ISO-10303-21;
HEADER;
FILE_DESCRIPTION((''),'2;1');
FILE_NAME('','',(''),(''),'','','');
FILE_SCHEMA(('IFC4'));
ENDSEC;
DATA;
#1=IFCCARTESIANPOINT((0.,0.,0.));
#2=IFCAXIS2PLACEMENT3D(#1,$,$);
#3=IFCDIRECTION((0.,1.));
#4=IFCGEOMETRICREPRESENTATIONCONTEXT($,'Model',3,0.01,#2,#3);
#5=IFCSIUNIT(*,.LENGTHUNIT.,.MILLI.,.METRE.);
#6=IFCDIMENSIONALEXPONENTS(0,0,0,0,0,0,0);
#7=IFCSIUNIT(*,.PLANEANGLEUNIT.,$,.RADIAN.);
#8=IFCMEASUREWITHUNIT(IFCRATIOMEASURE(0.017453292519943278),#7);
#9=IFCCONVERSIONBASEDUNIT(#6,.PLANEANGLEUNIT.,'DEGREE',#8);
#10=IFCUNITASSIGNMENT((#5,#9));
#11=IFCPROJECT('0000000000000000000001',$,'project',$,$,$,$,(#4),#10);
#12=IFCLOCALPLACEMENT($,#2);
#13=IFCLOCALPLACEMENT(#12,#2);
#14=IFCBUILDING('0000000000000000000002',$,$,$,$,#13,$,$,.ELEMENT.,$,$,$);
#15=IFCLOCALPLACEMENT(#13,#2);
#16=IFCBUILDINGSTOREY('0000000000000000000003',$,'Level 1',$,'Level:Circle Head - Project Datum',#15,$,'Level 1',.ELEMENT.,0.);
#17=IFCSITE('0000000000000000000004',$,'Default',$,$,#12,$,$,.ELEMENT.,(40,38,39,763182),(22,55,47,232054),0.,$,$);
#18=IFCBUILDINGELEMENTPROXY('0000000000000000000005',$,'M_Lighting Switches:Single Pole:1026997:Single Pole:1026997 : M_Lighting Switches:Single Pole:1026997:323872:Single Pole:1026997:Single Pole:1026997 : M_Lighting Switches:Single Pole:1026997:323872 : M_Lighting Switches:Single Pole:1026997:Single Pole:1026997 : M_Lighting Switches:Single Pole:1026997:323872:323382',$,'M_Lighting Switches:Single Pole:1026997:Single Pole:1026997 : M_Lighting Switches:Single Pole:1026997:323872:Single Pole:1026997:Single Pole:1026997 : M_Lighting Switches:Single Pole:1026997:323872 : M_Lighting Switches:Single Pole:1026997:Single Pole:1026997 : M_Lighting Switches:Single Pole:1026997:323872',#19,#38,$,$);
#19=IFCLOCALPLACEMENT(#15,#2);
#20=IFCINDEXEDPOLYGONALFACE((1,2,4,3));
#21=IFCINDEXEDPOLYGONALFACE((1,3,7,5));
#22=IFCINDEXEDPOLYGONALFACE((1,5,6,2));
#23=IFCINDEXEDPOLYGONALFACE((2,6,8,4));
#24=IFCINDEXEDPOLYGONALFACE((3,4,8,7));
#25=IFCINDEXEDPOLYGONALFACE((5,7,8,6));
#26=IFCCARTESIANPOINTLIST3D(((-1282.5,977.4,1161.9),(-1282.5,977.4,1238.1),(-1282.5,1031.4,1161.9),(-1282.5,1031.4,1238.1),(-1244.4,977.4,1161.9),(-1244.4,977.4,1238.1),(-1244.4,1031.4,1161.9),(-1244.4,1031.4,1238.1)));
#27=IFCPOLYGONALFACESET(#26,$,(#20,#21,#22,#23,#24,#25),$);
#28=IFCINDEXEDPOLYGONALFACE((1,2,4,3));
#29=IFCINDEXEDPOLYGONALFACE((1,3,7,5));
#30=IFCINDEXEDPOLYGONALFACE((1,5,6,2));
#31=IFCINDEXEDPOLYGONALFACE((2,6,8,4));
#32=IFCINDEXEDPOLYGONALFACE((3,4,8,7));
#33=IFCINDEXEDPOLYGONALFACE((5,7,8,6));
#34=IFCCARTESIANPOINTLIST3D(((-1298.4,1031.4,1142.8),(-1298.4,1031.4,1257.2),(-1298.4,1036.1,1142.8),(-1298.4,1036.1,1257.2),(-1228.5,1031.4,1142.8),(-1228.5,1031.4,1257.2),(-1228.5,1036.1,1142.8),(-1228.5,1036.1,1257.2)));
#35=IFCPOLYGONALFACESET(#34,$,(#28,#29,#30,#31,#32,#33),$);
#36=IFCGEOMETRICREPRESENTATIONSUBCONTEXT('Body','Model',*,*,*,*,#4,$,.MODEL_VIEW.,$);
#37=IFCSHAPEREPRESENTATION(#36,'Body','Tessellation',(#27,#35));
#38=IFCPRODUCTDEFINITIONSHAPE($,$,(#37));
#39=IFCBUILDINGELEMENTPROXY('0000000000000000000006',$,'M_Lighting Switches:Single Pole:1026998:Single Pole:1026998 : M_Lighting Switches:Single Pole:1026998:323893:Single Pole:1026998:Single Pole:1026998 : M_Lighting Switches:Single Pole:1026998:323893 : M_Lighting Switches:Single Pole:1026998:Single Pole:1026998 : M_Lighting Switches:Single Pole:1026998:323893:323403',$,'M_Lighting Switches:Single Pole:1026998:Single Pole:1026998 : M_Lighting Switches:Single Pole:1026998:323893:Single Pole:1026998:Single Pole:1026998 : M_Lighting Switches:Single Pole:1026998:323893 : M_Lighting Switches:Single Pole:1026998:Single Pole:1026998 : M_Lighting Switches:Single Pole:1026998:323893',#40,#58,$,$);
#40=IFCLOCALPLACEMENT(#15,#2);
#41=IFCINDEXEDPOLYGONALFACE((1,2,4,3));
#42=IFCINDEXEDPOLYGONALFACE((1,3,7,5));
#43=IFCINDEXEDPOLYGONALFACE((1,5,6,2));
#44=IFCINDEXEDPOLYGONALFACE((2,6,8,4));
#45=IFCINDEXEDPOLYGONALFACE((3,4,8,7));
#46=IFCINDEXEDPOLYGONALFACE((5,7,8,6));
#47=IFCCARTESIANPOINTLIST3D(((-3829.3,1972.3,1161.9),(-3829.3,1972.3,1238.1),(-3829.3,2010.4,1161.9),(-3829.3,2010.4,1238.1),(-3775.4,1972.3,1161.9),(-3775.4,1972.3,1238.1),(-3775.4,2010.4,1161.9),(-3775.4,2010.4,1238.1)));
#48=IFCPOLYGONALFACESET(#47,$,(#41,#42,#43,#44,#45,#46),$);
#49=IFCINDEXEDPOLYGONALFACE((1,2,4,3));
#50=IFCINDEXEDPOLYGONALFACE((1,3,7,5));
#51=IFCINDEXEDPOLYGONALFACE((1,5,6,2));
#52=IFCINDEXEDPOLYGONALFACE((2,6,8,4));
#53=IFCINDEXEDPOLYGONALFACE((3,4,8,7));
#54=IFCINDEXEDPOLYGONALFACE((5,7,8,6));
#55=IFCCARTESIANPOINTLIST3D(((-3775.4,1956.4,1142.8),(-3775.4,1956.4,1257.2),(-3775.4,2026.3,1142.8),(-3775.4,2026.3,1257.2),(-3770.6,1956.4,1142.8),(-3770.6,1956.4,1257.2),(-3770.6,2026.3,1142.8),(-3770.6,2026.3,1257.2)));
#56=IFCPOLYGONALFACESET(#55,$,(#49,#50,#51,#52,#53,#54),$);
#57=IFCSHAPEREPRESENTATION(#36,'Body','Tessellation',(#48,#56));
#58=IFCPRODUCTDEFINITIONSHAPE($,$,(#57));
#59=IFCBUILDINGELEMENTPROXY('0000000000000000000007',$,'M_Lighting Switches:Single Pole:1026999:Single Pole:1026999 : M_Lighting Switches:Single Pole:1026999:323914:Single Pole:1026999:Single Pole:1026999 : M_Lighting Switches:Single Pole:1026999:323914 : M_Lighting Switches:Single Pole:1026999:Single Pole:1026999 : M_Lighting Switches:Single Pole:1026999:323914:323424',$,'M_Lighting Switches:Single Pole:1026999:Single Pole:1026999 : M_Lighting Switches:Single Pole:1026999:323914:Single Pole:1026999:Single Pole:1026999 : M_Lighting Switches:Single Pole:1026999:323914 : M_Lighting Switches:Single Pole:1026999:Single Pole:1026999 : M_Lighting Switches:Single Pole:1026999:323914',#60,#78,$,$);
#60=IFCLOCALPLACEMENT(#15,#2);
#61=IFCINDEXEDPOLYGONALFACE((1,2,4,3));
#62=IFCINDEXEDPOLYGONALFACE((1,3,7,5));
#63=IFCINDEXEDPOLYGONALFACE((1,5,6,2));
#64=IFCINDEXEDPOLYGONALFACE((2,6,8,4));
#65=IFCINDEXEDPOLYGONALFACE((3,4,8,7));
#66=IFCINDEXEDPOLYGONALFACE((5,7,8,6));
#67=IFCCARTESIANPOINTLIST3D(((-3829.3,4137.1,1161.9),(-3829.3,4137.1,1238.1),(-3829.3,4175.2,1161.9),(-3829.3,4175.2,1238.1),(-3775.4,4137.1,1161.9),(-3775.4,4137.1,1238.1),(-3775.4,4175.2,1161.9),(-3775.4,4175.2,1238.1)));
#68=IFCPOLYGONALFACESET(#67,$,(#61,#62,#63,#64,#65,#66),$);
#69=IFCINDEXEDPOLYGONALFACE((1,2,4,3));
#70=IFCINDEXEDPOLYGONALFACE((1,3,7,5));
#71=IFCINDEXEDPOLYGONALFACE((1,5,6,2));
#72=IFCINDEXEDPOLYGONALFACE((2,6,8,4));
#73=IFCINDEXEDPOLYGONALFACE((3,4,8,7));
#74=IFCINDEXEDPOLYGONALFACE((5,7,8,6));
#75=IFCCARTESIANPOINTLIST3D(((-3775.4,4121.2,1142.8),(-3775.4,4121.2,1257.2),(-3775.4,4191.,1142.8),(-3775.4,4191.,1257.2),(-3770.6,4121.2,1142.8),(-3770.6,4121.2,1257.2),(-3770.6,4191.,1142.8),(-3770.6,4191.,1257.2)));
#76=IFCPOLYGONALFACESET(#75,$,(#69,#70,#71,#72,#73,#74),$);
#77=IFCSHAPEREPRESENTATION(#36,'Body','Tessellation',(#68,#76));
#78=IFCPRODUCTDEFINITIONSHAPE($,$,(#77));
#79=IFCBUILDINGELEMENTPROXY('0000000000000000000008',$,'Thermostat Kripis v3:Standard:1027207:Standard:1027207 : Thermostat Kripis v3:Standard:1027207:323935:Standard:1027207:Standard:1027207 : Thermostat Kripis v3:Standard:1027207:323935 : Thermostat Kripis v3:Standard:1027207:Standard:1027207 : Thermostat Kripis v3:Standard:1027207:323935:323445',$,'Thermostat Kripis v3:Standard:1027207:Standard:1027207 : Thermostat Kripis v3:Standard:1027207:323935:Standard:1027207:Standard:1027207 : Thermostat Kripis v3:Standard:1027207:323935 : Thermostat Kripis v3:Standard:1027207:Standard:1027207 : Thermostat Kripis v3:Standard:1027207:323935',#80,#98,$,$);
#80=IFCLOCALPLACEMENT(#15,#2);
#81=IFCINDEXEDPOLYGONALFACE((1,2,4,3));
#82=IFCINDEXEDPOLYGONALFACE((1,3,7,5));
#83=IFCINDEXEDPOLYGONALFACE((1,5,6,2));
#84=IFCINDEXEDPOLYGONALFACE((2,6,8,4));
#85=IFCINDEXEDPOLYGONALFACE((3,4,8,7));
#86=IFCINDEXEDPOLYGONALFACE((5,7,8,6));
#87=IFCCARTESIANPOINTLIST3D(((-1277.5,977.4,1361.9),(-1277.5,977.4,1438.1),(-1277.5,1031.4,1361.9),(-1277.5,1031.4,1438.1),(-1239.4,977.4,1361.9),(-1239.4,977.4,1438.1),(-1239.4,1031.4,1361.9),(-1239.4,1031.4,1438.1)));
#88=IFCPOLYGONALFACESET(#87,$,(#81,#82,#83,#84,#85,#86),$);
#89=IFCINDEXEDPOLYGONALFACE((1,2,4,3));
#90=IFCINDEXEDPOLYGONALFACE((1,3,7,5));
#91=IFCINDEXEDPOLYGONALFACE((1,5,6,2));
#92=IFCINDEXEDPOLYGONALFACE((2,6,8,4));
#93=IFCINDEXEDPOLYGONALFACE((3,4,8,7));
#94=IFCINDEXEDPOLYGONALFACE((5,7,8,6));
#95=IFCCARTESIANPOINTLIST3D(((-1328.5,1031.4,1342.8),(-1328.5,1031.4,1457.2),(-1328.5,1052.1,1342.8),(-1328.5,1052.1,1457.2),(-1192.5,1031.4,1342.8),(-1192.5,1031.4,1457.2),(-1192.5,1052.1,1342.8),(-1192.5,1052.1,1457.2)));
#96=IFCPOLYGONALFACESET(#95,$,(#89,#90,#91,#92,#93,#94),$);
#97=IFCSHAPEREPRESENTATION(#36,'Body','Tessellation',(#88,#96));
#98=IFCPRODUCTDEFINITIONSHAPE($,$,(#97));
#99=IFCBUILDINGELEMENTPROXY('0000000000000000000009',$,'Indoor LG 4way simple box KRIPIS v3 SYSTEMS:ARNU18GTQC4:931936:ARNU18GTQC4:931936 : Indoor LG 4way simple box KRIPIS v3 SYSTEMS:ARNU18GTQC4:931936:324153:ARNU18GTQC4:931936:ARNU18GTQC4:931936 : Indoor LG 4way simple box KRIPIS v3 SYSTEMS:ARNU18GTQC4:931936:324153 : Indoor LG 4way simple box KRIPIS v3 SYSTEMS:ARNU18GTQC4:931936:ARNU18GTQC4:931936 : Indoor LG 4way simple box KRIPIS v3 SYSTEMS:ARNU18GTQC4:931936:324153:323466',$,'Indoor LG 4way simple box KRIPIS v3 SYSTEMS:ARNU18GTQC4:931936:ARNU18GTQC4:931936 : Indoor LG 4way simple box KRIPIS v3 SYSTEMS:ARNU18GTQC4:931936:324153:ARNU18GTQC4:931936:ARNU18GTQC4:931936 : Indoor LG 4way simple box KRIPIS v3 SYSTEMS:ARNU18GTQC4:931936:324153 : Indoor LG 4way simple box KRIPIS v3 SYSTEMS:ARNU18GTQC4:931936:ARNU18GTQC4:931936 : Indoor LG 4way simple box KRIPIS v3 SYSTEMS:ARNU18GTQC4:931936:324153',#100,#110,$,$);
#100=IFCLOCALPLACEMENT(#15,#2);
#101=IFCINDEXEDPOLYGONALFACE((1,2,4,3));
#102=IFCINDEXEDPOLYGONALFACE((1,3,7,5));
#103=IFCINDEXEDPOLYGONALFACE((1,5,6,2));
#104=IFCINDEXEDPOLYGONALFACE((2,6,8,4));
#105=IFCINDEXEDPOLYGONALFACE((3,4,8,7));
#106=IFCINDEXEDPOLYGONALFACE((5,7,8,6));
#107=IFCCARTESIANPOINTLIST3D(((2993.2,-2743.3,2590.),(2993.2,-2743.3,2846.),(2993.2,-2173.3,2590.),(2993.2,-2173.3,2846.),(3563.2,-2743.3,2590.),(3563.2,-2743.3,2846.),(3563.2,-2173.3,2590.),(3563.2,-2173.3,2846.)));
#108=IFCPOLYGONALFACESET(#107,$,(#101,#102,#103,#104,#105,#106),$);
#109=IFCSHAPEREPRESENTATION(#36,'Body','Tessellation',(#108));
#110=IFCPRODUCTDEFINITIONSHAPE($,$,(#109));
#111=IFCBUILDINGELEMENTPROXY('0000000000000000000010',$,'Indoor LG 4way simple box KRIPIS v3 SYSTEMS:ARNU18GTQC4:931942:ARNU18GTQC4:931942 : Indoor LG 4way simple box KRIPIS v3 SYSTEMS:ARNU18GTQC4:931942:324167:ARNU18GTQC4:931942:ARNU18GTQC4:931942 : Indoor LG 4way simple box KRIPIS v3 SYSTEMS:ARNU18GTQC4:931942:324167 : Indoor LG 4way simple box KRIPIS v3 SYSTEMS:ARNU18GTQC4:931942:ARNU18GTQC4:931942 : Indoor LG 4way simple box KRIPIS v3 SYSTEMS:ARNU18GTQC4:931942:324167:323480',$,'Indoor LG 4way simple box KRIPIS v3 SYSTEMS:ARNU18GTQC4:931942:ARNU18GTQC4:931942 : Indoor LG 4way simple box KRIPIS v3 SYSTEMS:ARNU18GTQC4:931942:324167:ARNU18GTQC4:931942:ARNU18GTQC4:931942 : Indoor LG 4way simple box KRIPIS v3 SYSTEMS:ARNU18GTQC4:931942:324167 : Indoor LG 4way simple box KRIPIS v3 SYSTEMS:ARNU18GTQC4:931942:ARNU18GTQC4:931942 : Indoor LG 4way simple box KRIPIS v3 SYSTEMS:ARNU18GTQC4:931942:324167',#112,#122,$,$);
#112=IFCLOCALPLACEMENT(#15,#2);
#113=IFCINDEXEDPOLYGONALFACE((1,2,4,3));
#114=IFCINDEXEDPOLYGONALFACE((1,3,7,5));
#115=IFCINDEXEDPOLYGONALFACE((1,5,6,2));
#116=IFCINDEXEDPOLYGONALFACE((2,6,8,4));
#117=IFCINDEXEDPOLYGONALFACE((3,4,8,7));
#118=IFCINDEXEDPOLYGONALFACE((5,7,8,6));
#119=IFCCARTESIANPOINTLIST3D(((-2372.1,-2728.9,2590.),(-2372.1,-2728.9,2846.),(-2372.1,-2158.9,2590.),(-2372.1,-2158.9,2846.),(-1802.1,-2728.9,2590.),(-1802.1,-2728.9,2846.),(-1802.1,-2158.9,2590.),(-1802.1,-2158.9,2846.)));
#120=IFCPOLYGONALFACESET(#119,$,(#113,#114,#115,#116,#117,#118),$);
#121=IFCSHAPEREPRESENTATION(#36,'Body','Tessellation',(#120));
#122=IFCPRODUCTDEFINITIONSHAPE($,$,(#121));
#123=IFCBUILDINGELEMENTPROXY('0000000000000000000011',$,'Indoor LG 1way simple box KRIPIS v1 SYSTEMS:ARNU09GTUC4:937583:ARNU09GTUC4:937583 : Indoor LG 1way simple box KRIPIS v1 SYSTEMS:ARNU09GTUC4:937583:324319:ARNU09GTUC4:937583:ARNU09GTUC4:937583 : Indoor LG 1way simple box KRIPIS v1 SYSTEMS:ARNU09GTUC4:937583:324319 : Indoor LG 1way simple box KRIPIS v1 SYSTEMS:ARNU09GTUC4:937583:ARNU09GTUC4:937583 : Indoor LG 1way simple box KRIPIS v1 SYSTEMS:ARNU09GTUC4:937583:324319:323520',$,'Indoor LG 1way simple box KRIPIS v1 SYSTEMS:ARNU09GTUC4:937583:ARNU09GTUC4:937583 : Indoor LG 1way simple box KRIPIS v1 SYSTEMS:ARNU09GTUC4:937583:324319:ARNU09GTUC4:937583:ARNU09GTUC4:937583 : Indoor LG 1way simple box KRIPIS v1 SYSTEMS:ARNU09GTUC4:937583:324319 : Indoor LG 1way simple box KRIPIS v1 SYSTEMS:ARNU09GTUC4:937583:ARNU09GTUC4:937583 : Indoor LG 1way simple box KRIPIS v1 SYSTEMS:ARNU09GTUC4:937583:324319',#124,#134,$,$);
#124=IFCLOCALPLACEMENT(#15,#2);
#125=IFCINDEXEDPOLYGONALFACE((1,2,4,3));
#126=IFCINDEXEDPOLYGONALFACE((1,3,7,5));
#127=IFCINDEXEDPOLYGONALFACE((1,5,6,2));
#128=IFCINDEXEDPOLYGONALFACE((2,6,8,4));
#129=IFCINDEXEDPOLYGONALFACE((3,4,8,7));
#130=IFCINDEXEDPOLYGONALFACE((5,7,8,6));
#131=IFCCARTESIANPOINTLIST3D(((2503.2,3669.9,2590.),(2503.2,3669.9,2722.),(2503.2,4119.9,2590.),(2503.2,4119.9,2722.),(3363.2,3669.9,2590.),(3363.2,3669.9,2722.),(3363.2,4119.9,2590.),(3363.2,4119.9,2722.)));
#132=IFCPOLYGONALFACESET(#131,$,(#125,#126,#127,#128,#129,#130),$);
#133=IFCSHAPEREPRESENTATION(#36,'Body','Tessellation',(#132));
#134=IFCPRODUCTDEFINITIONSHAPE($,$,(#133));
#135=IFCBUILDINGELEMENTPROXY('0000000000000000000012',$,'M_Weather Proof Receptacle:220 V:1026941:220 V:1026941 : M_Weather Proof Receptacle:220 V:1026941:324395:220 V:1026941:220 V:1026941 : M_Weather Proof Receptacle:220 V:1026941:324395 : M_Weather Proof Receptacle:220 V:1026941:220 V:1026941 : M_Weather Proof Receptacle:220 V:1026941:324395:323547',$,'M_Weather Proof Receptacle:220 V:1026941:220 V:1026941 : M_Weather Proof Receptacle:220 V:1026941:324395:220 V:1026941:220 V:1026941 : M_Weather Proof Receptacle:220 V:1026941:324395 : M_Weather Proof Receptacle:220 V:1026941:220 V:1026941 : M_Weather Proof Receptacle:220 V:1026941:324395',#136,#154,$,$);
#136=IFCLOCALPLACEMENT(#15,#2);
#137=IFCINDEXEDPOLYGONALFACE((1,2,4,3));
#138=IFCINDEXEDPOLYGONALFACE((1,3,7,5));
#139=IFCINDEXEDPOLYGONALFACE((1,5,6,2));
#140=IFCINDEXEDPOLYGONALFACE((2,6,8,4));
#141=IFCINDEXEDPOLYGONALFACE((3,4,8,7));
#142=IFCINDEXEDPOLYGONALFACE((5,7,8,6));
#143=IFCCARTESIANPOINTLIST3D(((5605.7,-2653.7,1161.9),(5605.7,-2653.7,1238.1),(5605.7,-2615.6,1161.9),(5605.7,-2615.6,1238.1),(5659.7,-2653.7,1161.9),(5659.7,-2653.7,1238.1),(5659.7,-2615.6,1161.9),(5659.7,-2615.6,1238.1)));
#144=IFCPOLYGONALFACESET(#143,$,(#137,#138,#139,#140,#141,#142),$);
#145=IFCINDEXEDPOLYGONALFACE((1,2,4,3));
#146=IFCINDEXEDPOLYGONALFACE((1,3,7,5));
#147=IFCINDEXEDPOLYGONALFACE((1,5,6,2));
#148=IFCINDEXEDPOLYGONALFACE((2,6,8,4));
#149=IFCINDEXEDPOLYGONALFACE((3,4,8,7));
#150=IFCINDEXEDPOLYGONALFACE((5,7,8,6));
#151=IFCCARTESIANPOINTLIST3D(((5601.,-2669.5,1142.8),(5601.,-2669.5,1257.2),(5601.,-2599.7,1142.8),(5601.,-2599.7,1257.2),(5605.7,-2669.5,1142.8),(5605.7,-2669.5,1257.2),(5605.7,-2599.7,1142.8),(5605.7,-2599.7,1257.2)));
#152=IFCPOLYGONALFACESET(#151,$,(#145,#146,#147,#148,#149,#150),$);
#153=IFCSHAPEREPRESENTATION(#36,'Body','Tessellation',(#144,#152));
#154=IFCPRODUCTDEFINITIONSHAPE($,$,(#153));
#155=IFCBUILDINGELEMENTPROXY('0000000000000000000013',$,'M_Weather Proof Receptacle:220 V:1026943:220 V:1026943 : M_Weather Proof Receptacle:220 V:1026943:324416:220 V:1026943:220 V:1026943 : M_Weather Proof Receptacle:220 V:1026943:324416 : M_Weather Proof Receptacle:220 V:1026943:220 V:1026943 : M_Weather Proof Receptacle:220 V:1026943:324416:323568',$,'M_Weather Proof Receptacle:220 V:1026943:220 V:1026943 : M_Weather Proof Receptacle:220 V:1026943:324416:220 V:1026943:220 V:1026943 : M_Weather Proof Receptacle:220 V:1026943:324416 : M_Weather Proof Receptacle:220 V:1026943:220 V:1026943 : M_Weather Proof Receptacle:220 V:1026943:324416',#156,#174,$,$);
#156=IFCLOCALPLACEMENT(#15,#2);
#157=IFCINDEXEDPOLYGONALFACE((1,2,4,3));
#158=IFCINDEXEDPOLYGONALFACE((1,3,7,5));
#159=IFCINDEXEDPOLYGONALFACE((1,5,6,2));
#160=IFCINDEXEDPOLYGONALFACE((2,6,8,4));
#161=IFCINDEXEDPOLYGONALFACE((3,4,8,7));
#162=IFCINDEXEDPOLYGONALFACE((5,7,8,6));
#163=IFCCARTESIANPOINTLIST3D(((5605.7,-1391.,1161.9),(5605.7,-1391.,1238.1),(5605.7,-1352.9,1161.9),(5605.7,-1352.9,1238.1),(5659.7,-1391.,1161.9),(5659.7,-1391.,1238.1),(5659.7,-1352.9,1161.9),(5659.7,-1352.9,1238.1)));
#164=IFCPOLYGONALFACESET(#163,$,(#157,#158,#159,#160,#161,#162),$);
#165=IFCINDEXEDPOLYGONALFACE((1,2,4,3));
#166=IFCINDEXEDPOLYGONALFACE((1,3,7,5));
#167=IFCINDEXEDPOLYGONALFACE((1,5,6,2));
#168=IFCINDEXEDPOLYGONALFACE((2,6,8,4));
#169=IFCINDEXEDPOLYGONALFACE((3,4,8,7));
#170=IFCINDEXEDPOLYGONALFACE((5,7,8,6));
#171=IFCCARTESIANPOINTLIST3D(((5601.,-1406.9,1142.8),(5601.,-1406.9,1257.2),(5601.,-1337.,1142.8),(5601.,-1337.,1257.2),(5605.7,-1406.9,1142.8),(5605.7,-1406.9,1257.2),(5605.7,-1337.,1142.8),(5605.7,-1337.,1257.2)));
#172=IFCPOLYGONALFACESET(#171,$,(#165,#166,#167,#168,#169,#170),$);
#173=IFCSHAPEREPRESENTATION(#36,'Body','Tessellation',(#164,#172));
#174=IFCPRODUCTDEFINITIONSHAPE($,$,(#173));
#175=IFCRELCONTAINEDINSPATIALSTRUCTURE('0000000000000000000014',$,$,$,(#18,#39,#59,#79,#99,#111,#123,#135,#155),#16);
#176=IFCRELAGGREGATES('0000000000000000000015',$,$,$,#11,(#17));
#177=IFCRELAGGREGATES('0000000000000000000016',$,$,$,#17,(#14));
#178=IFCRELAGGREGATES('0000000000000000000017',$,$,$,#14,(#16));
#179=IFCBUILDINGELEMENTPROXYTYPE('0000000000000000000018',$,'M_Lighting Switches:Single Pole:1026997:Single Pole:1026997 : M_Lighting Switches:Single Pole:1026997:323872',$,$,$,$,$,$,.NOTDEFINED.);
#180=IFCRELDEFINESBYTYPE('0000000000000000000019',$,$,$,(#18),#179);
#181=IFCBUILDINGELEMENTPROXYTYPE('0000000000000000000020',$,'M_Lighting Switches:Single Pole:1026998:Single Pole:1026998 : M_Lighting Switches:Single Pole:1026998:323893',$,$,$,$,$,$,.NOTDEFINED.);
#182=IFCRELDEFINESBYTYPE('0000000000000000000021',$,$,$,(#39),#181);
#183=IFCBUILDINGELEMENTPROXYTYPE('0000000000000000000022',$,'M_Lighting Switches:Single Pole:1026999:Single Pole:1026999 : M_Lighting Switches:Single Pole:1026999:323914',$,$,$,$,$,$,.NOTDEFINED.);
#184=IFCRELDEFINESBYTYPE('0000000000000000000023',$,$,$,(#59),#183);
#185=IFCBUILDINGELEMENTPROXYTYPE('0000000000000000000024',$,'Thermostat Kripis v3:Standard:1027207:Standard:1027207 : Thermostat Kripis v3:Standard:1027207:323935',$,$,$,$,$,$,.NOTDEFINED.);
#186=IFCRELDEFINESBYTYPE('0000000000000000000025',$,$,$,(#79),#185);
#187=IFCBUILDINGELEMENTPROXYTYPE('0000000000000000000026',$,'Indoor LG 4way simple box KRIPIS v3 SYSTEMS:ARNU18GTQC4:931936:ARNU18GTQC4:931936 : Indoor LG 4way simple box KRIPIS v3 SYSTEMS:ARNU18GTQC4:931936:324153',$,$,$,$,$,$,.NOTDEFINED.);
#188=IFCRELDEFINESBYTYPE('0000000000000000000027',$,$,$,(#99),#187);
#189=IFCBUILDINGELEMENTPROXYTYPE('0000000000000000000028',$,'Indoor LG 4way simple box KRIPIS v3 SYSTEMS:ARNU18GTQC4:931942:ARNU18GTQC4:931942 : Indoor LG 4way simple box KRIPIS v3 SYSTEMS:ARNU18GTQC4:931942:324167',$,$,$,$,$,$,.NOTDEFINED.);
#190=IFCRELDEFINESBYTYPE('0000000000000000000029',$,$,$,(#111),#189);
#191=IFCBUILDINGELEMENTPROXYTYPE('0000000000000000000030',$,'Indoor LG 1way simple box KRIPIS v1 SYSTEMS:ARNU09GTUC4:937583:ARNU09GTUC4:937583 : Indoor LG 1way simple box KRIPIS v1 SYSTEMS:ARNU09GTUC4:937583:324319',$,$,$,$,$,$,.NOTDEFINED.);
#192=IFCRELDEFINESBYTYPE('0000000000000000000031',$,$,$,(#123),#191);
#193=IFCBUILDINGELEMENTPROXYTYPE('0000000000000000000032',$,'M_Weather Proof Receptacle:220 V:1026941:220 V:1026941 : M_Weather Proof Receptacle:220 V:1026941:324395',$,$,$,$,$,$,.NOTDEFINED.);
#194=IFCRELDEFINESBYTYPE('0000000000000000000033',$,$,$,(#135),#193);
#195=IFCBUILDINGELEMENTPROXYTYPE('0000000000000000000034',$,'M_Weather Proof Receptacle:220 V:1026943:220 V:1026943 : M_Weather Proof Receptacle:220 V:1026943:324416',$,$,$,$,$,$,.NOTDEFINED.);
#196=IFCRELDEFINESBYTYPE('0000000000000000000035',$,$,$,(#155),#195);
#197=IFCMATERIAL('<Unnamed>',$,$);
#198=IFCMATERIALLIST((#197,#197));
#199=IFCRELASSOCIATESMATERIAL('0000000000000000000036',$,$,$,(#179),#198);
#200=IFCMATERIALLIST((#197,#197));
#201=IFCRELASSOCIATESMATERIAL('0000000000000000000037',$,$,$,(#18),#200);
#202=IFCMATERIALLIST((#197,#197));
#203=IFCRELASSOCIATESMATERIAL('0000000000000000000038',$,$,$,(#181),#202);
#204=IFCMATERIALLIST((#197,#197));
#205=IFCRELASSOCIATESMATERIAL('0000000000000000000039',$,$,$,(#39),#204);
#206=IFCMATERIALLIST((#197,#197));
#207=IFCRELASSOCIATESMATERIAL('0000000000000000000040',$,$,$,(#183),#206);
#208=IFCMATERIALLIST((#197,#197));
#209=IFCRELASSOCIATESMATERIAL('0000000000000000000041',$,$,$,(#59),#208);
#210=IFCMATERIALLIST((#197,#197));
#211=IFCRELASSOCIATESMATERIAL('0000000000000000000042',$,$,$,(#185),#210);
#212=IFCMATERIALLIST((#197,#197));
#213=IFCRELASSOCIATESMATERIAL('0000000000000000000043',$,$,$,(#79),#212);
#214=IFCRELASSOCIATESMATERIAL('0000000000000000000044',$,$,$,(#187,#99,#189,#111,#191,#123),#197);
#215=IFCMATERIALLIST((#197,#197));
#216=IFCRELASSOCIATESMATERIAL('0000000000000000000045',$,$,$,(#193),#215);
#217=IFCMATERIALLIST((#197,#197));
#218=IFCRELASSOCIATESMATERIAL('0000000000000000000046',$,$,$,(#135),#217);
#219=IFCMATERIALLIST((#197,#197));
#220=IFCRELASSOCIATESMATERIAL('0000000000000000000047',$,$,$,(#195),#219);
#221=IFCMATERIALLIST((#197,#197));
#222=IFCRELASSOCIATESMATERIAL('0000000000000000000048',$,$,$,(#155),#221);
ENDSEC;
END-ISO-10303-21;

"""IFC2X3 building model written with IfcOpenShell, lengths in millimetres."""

from ifc_helpers import new_model, entity, si_unit, converted_unit, direction, frame, frame_2d, origin, origin_2d_with_axis, place, context, subcontext, project, spatial, rectangle, extrude, source, transform, mapped, material, material_list, type_object, type_shapes, element, save


model = new_model("IFC2X3")

# Units and contexts
model_context = context("Model", 3, precision=0.01, world=origin(), true_north=direction((0.0, 1.0)))
body_context = subcontext(model_context, "Body", "Model", "MODEL_VIEW")
ifc_project = project(units=[si_unit("LENGTHUNIT", "METRE", prefix="MILLI"), converted_unit("PLANEANGLEUNIT", "DEGREE", entity("IfcRatioMeasure", 0.017453292519943278), si_unit("PLANEANGLEUNIT", "RADIAN"), dimensions=[0, 0, 0, 0, 0, 0, 0])], contexts=[model_context])

# Site, building, storey
site_placement = place(None, origin())
site = spatial("IfcSite", under=ifc_project, at=site_placement, Name="Default", CompositionType="ELEMENT", RefLatitude=(40, 38, 39, 763182), RefLongitude=(22, 55, 47, 232054), RefElevation=0.0)
building_placement = place(site_placement, origin())
building = spatial("IfcBuilding", under=site, at=building_placement, CompositionType="ELEMENT")
storey_placement = place(building_placement, origin())
storey = spatial("IfcBuildingStorey", under=building, at=storey_placement, Name="Level 1", ObjectType="Level:Circle Head - Project Datum", LongName="Level 1", CompositionType="ELEMENT", Elevation=0.0)

# Shared definitions
ifc_material_1 = material(Name="<Unnamed>")

# Building element proxies
ifc_material_list_1 = material_list([ifc_material_1, ifc_material_1])
ifc_material_list_2 = material_list([ifc_material_1, ifc_material_1])
building_element_proxy_type_1 = type_object("IfcBuildingElementProxyType", Name="M_Lighting Switches:Single Pole:1026997:Single Pole:1026997 : M_Lighting Switches:Single Pole:1026997:323872", PredefinedType="NOTDEFINED", material=ifc_material_list_2)
shared_shape_1 = source(origin(), body_context, "Body", "SweptSolid", [
    extrude(rectangle(XDim=38.1, YDim=54.0, at=frame_2d((0.0, 0.0), x_axis=(1.0, 0.0))), frame((-1263.5, 1004.4, 1161.9)), (0.0, 0.0, 1.0), 76.2),
    extrude(rectangle(XDim=69.8, YDim=4.8, at=frame_2d((0.0, 0.0), x_axis=(1.0, 0.0))), frame((-1263.5, 1033.7, 1142.8)), (0.0, 0.0, 1.0), 114.3),
])
type_shapes(building_element_proxy_type_1, [shared_shape_1])
proxy_1_placement = place(storey_placement, origin())
element("IfcBuildingElementProxy", 1, at=proxy_1_placement, inside=storey, type_object=building_element_proxy_type_1, material=ifc_material_list_1, Name="M_Lighting Switches:Single Pole:1026997:Single Pole:1026997 : M_Lighting Switches:Single Pole:1026997:323872:Single Pole:1026997:Single Pole:1026997 : M_Lighting Switches:Single Pole:1026997:323872 : M_Lighting Switches:Single Pole:1026997:Single Pole:1026997 : M_Lighting Switches:Single Pole:1026997:323872:323382", ObjectType="M_Lighting Switches:Single Pole:1026997:Single Pole:1026997 : M_Lighting Switches:Single Pole:1026997:323872:Single Pole:1026997:Single Pole:1026997 : M_Lighting Switches:Single Pole:1026997:323872 : M_Lighting Switches:Single Pole:1026997:Single Pole:1026997 : M_Lighting Switches:Single Pole:1026997:323872", context=body_context, shape_type="MappedRepresentation", body=[
    mapped(shared_shape_1, transform((0.0, 0.0, 0.0), scale=1.0)),
])
ifc_material_list_3 = material_list([ifc_material_1, ifc_material_1])
ifc_material_list_4 = material_list([ifc_material_1, ifc_material_1])
building_element_proxy_type_2 = type_object("IfcBuildingElementProxyType", Name="M_Lighting Switches:Single Pole:1026998:Single Pole:1026998 : M_Lighting Switches:Single Pole:1026998:323893", PredefinedType="NOTDEFINED", material=ifc_material_list_4)
shared_shape_2 = source(origin(), body_context, "Body", "SweptSolid", [
    extrude(rectangle(XDim=38.1, YDim=54.0, at=frame_2d((0.0, 0.0), x_axis=(1.0, 0.0))), frame((-3802.3, 1991.4, 1161.9), z_axis=(0.0, 0.0, 1.0), x_axis=(0.0, -1.0, 0.0)), (0.0, 0.0, 1.0), 76.2),
    extrude(rectangle(XDim=69.8, YDim=4.8, at=frame_2d((0.0, 0.0), x_axis=(1.0, 0.0))), frame((-3773.0, 1991.4, 1142.8), z_axis=(0.0, 0.0, 1.0), x_axis=(0.0, -1.0, 0.0)), (0.0, 0.0, 1.0), 114.3),
])
type_shapes(building_element_proxy_type_2, [shared_shape_2])
proxy_2_placement = place(storey_placement, origin())
element("IfcBuildingElementProxy", 2, at=proxy_2_placement, inside=storey, type_object=building_element_proxy_type_2, material=ifc_material_list_3, Name="M_Lighting Switches:Single Pole:1026998:Single Pole:1026998 : M_Lighting Switches:Single Pole:1026998:323893:Single Pole:1026998:Single Pole:1026998 : M_Lighting Switches:Single Pole:1026998:323893 : M_Lighting Switches:Single Pole:1026998:Single Pole:1026998 : M_Lighting Switches:Single Pole:1026998:323893:323403", ObjectType="M_Lighting Switches:Single Pole:1026998:Single Pole:1026998 : M_Lighting Switches:Single Pole:1026998:323893:Single Pole:1026998:Single Pole:1026998 : M_Lighting Switches:Single Pole:1026998:323893 : M_Lighting Switches:Single Pole:1026998:Single Pole:1026998 : M_Lighting Switches:Single Pole:1026998:323893", context=body_context, shape_type="MappedRepresentation", body=[
    mapped(shared_shape_2, transform((0.0, 0.0, 0.0), scale=1.0)),
])
ifc_material_list_5 = material_list([ifc_material_1, ifc_material_1])
ifc_material_list_6 = material_list([ifc_material_1, ifc_material_1])
building_element_proxy_type_3 = type_object("IfcBuildingElementProxyType", Name="M_Lighting Switches:Single Pole:1026999:Single Pole:1026999 : M_Lighting Switches:Single Pole:1026999:323914", PredefinedType="NOTDEFINED", material=ifc_material_list_6)
shared_shape_3 = source(origin(), body_context, "Body", "SweptSolid", [
    extrude(rectangle(XDim=38.1, YDim=54.0, at=frame_2d((0.0, 0.0), x_axis=(1.0, 0.0))), frame((-3802.3, 4156.1, 1161.9), z_axis=(0.0, 0.0, 1.0), x_axis=(0.0, -1.0, 0.0)), (0.0, 0.0, 1.0), 76.2),
    extrude(rectangle(XDim=69.8, YDim=4.8, at=frame_2d((0.0, 0.0), x_axis=(1.0, 0.0))), frame((-3773.0, 4156.1, 1142.8), z_axis=(0.0, 0.0, 1.0), x_axis=(0.0, -1.0, 0.0)), (0.0, 0.0, 1.0), 114.3),
])
type_shapes(building_element_proxy_type_3, [shared_shape_3])
proxy_3_placement = place(storey_placement, origin())
element("IfcBuildingElementProxy", 3, at=proxy_3_placement, inside=storey, type_object=building_element_proxy_type_3, material=ifc_material_list_5, Name="M_Lighting Switches:Single Pole:1026999:Single Pole:1026999 : M_Lighting Switches:Single Pole:1026999:323914:Single Pole:1026999:Single Pole:1026999 : M_Lighting Switches:Single Pole:1026999:323914 : M_Lighting Switches:Single Pole:1026999:Single Pole:1026999 : M_Lighting Switches:Single Pole:1026999:323914:323424", ObjectType="M_Lighting Switches:Single Pole:1026999:Single Pole:1026999 : M_Lighting Switches:Single Pole:1026999:323914:Single Pole:1026999:Single Pole:1026999 : M_Lighting Switches:Single Pole:1026999:323914 : M_Lighting Switches:Single Pole:1026999:Single Pole:1026999 : M_Lighting Switches:Single Pole:1026999:323914", context=body_context, shape_type="MappedRepresentation", body=[
    mapped(shared_shape_3, transform((0.0, 0.0, 0.0), scale=1.0)),
])
ifc_material_list_7 = material_list([ifc_material_1, ifc_material_1])
ifc_material_list_8 = material_list([ifc_material_1, ifc_material_1])
building_element_proxy_type_4 = type_object("IfcBuildingElementProxyType", Name="Thermostat Kripis v3:Standard:1027207:Standard:1027207 : Thermostat Kripis v3:Standard:1027207:323935", PredefinedType="NOTDEFINED", material=ifc_material_list_8)
shared_shape_4 = source(origin(), body_context, "Body", "SweptSolid", [
    extrude(rectangle(XDim=38.1, YDim=54.0, at=frame_2d((0.0, 0.0), x_axis=(1.0, 0.0))), frame((-1258.5, 1004.4, 1361.9)), (0.0, 0.0, 1.0), 76.2),
    extrude(rectangle(XDim=136.0, YDim=20.7, at=frame_2d((0.0, 0.0), x_axis=(1.0, 0.0))), frame((-1260.5, 1041.7, 1342.8)), (0.0, 0.0, 1.0), 114.3),
])
type_shapes(building_element_proxy_type_4, [shared_shape_4])
proxy_4_placement = place(storey_placement, origin())
element("IfcBuildingElementProxy", 4, at=proxy_4_placement, inside=storey, type_object=building_element_proxy_type_4, material=ifc_material_list_7, Name="Thermostat Kripis v3:Standard:1027207:Standard:1027207 : Thermostat Kripis v3:Standard:1027207:323935:Standard:1027207:Standard:1027207 : Thermostat Kripis v3:Standard:1027207:323935 : Thermostat Kripis v3:Standard:1027207:Standard:1027207 : Thermostat Kripis v3:Standard:1027207:323935:323445", ObjectType="Thermostat Kripis v3:Standard:1027207:Standard:1027207 : Thermostat Kripis v3:Standard:1027207:323935:Standard:1027207:Standard:1027207 : Thermostat Kripis v3:Standard:1027207:323935 : Thermostat Kripis v3:Standard:1027207:Standard:1027207 : Thermostat Kripis v3:Standard:1027207:323935", context=body_context, shape_type="MappedRepresentation", body=[
    mapped(shared_shape_4, transform((0.0, 0.0, 0.0), scale=1.0)),
])
building_element_proxy_type_5 = type_object("IfcBuildingElementProxyType", Name="Indoor LG 4way simple box KRIPIS v3 SYSTEMS:ARNU18GTQC4:931936:ARNU18GTQC4:931936 : Indoor LG 4way simple box KRIPIS v3 SYSTEMS:ARNU18GTQC4:931936:324153", PredefinedType="NOTDEFINED", material=ifc_material_1)
shared_shape_5 = source(origin(), body_context, "Body", "SweptSolid", [
    extrude(rectangle(XDim=570.0, YDim=570.0, at=origin_2d_with_axis()), frame((3278.2, -2458.3, 2590.0), z_axis=(0.0, 0.0, 1.0), x_axis=(0.0, 1.0, 0.0)), (0.0, 0.0, 1.0), 256.0),
])
type_shapes(building_element_proxy_type_5, [shared_shape_5])
proxy_5_placement = place(storey_placement, origin())
element("IfcBuildingElementProxy", 5, at=proxy_5_placement, inside=storey, type_object=building_element_proxy_type_5, material=ifc_material_1, Name="Indoor LG 4way simple box KRIPIS v3 SYSTEMS:ARNU18GTQC4:931936:ARNU18GTQC4:931936 : Indoor LG 4way simple box KRIPIS v3 SYSTEMS:ARNU18GTQC4:931936:324153:ARNU18GTQC4:931936:ARNU18GTQC4:931936 : Indoor LG 4way simple box KRIPIS v3 SYSTEMS:ARNU18GTQC4:931936:324153 : Indoor LG 4way simple box KRIPIS v3 SYSTEMS:ARNU18GTQC4:931936:ARNU18GTQC4:931936 : Indoor LG 4way simple box KRIPIS v3 SYSTEMS:ARNU18GTQC4:931936:324153:323466", ObjectType="Indoor LG 4way simple box KRIPIS v3 SYSTEMS:ARNU18GTQC4:931936:ARNU18GTQC4:931936 : Indoor LG 4way simple box KRIPIS v3 SYSTEMS:ARNU18GTQC4:931936:324153:ARNU18GTQC4:931936:ARNU18GTQC4:931936 : Indoor LG 4way simple box KRIPIS v3 SYSTEMS:ARNU18GTQC4:931936:324153 : Indoor LG 4way simple box KRIPIS v3 SYSTEMS:ARNU18GTQC4:931936:ARNU18GTQC4:931936 : Indoor LG 4way simple box KRIPIS v3 SYSTEMS:ARNU18GTQC4:931936:324153", context=body_context, shape_type="MappedRepresentation", body=[
    mapped(shared_shape_5, transform((0.0, 0.0, 0.0), scale=1.0)),
])
building_element_proxy_type_6 = type_object("IfcBuildingElementProxyType", Name="Indoor LG 4way simple box KRIPIS v3 SYSTEMS:ARNU18GTQC4:931942:ARNU18GTQC4:931942 : Indoor LG 4way simple box KRIPIS v3 SYSTEMS:ARNU18GTQC4:931942:324167", PredefinedType="NOTDEFINED", material=ifc_material_1)
shared_shape_6 = source(origin(), body_context, "Body", "SweptSolid", [
    extrude(rectangle(XDim=570.0, YDim=570.0, at=frame_2d((0.0, 0.0), x_axis=(1.0, 0.0))), frame((-2087.1, -2443.9, 2590.0), z_axis=(0.0, 0.0, 1.0), x_axis=(0.0, 1.0, 0.0)), (0.0, 0.0, 1.0), 256.0),
])
type_shapes(building_element_proxy_type_6, [shared_shape_6])
proxy_6_placement = place(storey_placement, origin())
element("IfcBuildingElementProxy", 6, at=proxy_6_placement, inside=storey, type_object=building_element_proxy_type_6, material=ifc_material_1, Name="Indoor LG 4way simple box KRIPIS v3 SYSTEMS:ARNU18GTQC4:931942:ARNU18GTQC4:931942 : Indoor LG 4way simple box KRIPIS v3 SYSTEMS:ARNU18GTQC4:931942:324167:ARNU18GTQC4:931942:ARNU18GTQC4:931942 : Indoor LG 4way simple box KRIPIS v3 SYSTEMS:ARNU18GTQC4:931942:324167 : Indoor LG 4way simple box KRIPIS v3 SYSTEMS:ARNU18GTQC4:931942:ARNU18GTQC4:931942 : Indoor LG 4way simple box KRIPIS v3 SYSTEMS:ARNU18GTQC4:931942:324167:323480", ObjectType="Indoor LG 4way simple box KRIPIS v3 SYSTEMS:ARNU18GTQC4:931942:ARNU18GTQC4:931942 : Indoor LG 4way simple box KRIPIS v3 SYSTEMS:ARNU18GTQC4:931942:324167:ARNU18GTQC4:931942:ARNU18GTQC4:931942 : Indoor LG 4way simple box KRIPIS v3 SYSTEMS:ARNU18GTQC4:931942:324167 : Indoor LG 4way simple box KRIPIS v3 SYSTEMS:ARNU18GTQC4:931942:ARNU18GTQC4:931942 : Indoor LG 4way simple box KRIPIS v3 SYSTEMS:ARNU18GTQC4:931942:324167", context=body_context, shape_type="MappedRepresentation", body=[
    mapped(shared_shape_6, transform((0.0, 0.0, 0.0), scale=1.0)),
])
building_element_proxy_type_7 = type_object("IfcBuildingElementProxyType", Name="Indoor LG 1way simple box KRIPIS v1 SYSTEMS:ARNU09GTUC4:937583:ARNU09GTUC4:937583 : Indoor LG 1way simple box KRIPIS v1 SYSTEMS:ARNU09GTUC4:937583:324319", PredefinedType="NOTDEFINED", material=ifc_material_1)
shared_shape_7 = source(origin(), body_context, "Body", "SweptSolid", [
    extrude(rectangle(XDim=860.0, YDim=450.0, at=frame_2d((0.0, 0.0), x_axis=(1.0, 0.0))), frame((2933.2, 3894.9, 2590.0)), (0.0, 0.0, 1.0), 132.0),
])
type_shapes(building_element_proxy_type_7, [shared_shape_7])
proxy_7_placement = place(storey_placement, origin())
element("IfcBuildingElementProxy", 7, at=proxy_7_placement, inside=storey, type_object=building_element_proxy_type_7, material=ifc_material_1, Name="Indoor LG 1way simple box KRIPIS v1 SYSTEMS:ARNU09GTUC4:937583:ARNU09GTUC4:937583 : Indoor LG 1way simple box KRIPIS v1 SYSTEMS:ARNU09GTUC4:937583:324319:ARNU09GTUC4:937583:ARNU09GTUC4:937583 : Indoor LG 1way simple box KRIPIS v1 SYSTEMS:ARNU09GTUC4:937583:324319 : Indoor LG 1way simple box KRIPIS v1 SYSTEMS:ARNU09GTUC4:937583:ARNU09GTUC4:937583 : Indoor LG 1way simple box KRIPIS v1 SYSTEMS:ARNU09GTUC4:937583:324319:323520", ObjectType="Indoor LG 1way simple box KRIPIS v1 SYSTEMS:ARNU09GTUC4:937583:ARNU09GTUC4:937583 : Indoor LG 1way simple box KRIPIS v1 SYSTEMS:ARNU09GTUC4:937583:324319:ARNU09GTUC4:937583:ARNU09GTUC4:937583 : Indoor LG 1way simple box KRIPIS v1 SYSTEMS:ARNU09GTUC4:937583:324319 : Indoor LG 1way simple box KRIPIS v1 SYSTEMS:ARNU09GTUC4:937583:ARNU09GTUC4:937583 : Indoor LG 1way simple box KRIPIS v1 SYSTEMS:ARNU09GTUC4:937583:324319", context=body_context, shape_type="MappedRepresentation", body=[
    mapped(shared_shape_7, transform((0.0, 0.0, 0.0), scale=1.0)),
])
ifc_material_list_9 = material_list([ifc_material_1, ifc_material_1])
ifc_material_list_10 = material_list([ifc_material_1, ifc_material_1])
building_element_proxy_type_8 = type_object("IfcBuildingElementProxyType", Name="M_Weather Proof Receptacle:220 V:1026941:220 V:1026941 : M_Weather Proof Receptacle:220 V:1026941:324395", PredefinedType="NOTDEFINED", material=ifc_material_list_10)
shared_shape_8 = source(origin(), body_context, "Body", "SweptSolid", [
    extrude(rectangle(XDim=38.1, YDim=54.0, at=frame_2d((0.0, 0.0), x_axis=(1.0, 0.0))), frame((5632.7, -2634.6, 1161.9), z_axis=(0.0, 0.0, 1.0), x_axis=(0.0, 1.0, 0.0)), (0.0, 0.0, 1.0), 76.2),
    extrude(rectangle(XDim=69.8, YDim=4.8, at=frame_2d((0.0, 0.0), x_axis=(1.0, 0.0))), frame((5603.3, -2634.6, 1142.8), z_axis=(0.0, 0.0, 1.0), x_axis=(0.0, 1.0, 0.0)), (0.0, 0.0, 1.0), 114.3),
])
type_shapes(building_element_proxy_type_8, [shared_shape_8])
proxy_8_placement = place(storey_placement, origin())
element("IfcBuildingElementProxy", 8, at=proxy_8_placement, inside=storey, type_object=building_element_proxy_type_8, material=ifc_material_list_9, Name="M_Weather Proof Receptacle:220 V:1026941:220 V:1026941 : M_Weather Proof Receptacle:220 V:1026941:324395:220 V:1026941:220 V:1026941 : M_Weather Proof Receptacle:220 V:1026941:324395 : M_Weather Proof Receptacle:220 V:1026941:220 V:1026941 : M_Weather Proof Receptacle:220 V:1026941:324395:323547", ObjectType="M_Weather Proof Receptacle:220 V:1026941:220 V:1026941 : M_Weather Proof Receptacle:220 V:1026941:324395:220 V:1026941:220 V:1026941 : M_Weather Proof Receptacle:220 V:1026941:324395 : M_Weather Proof Receptacle:220 V:1026941:220 V:1026941 : M_Weather Proof Receptacle:220 V:1026941:324395", context=body_context, shape_type="MappedRepresentation", body=[
    mapped(shared_shape_8, transform((0.0, 0.0, 0.0), scale=1.0)),
])
ifc_material_list_11 = material_list([ifc_material_1, ifc_material_1])
ifc_material_list_12 = material_list([ifc_material_1, ifc_material_1])
building_element_proxy_type_9 = type_object("IfcBuildingElementProxyType", Name="M_Weather Proof Receptacle:220 V:1026943:220 V:1026943 : M_Weather Proof Receptacle:220 V:1026943:324416", PredefinedType="NOTDEFINED", material=ifc_material_list_12)
shared_shape_9 = source(origin(), body_context, "Body", "SweptSolid", [
    extrude(rectangle(XDim=38.1, YDim=54.0, at=origin_2d_with_axis()), frame((5632.7, -1372.0, 1161.9), z_axis=(0.0, 0.0, 1.0), x_axis=(0.0, 1.0, 0.0)), (0.0, 0.0, 1.0), 76.2),
    extrude(rectangle(XDim=69.8, YDim=4.8, at=frame_2d((0.0, 0.0), x_axis=(1.0, 0.0))), frame((5603.3, -1372.0, 1142.8), z_axis=(0.0, 0.0, 1.0), x_axis=(0.0, 1.0, 0.0)), (0.0, 0.0, 1.0), 114.3),
])
type_shapes(building_element_proxy_type_9, [shared_shape_9])
proxy_9_placement = place(storey_placement, origin())
element("IfcBuildingElementProxy", 9, at=proxy_9_placement, inside=storey, type_object=building_element_proxy_type_9, material=ifc_material_list_11, Name="M_Weather Proof Receptacle:220 V:1026943:220 V:1026943 : M_Weather Proof Receptacle:220 V:1026943:324416:220 V:1026943:220 V:1026943 : M_Weather Proof Receptacle:220 V:1026943:324416 : M_Weather Proof Receptacle:220 V:1026943:220 V:1026943 : M_Weather Proof Receptacle:220 V:1026943:324416:323568", ObjectType="M_Weather Proof Receptacle:220 V:1026943:220 V:1026943 : M_Weather Proof Receptacle:220 V:1026943:324416:220 V:1026943:220 V:1026943 : M_Weather Proof Receptacle:220 V:1026943:324416 : M_Weather Proof Receptacle:220 V:1026943:220 V:1026943 : M_Weather Proof Receptacle:220 V:1026943:324416", context=body_context, shape_type="MappedRepresentation", body=[
    mapped(shared_shape_9, transform((0.0, 0.0, 0.0), scale=1.0)),
])

save(model, "model.ifc")
